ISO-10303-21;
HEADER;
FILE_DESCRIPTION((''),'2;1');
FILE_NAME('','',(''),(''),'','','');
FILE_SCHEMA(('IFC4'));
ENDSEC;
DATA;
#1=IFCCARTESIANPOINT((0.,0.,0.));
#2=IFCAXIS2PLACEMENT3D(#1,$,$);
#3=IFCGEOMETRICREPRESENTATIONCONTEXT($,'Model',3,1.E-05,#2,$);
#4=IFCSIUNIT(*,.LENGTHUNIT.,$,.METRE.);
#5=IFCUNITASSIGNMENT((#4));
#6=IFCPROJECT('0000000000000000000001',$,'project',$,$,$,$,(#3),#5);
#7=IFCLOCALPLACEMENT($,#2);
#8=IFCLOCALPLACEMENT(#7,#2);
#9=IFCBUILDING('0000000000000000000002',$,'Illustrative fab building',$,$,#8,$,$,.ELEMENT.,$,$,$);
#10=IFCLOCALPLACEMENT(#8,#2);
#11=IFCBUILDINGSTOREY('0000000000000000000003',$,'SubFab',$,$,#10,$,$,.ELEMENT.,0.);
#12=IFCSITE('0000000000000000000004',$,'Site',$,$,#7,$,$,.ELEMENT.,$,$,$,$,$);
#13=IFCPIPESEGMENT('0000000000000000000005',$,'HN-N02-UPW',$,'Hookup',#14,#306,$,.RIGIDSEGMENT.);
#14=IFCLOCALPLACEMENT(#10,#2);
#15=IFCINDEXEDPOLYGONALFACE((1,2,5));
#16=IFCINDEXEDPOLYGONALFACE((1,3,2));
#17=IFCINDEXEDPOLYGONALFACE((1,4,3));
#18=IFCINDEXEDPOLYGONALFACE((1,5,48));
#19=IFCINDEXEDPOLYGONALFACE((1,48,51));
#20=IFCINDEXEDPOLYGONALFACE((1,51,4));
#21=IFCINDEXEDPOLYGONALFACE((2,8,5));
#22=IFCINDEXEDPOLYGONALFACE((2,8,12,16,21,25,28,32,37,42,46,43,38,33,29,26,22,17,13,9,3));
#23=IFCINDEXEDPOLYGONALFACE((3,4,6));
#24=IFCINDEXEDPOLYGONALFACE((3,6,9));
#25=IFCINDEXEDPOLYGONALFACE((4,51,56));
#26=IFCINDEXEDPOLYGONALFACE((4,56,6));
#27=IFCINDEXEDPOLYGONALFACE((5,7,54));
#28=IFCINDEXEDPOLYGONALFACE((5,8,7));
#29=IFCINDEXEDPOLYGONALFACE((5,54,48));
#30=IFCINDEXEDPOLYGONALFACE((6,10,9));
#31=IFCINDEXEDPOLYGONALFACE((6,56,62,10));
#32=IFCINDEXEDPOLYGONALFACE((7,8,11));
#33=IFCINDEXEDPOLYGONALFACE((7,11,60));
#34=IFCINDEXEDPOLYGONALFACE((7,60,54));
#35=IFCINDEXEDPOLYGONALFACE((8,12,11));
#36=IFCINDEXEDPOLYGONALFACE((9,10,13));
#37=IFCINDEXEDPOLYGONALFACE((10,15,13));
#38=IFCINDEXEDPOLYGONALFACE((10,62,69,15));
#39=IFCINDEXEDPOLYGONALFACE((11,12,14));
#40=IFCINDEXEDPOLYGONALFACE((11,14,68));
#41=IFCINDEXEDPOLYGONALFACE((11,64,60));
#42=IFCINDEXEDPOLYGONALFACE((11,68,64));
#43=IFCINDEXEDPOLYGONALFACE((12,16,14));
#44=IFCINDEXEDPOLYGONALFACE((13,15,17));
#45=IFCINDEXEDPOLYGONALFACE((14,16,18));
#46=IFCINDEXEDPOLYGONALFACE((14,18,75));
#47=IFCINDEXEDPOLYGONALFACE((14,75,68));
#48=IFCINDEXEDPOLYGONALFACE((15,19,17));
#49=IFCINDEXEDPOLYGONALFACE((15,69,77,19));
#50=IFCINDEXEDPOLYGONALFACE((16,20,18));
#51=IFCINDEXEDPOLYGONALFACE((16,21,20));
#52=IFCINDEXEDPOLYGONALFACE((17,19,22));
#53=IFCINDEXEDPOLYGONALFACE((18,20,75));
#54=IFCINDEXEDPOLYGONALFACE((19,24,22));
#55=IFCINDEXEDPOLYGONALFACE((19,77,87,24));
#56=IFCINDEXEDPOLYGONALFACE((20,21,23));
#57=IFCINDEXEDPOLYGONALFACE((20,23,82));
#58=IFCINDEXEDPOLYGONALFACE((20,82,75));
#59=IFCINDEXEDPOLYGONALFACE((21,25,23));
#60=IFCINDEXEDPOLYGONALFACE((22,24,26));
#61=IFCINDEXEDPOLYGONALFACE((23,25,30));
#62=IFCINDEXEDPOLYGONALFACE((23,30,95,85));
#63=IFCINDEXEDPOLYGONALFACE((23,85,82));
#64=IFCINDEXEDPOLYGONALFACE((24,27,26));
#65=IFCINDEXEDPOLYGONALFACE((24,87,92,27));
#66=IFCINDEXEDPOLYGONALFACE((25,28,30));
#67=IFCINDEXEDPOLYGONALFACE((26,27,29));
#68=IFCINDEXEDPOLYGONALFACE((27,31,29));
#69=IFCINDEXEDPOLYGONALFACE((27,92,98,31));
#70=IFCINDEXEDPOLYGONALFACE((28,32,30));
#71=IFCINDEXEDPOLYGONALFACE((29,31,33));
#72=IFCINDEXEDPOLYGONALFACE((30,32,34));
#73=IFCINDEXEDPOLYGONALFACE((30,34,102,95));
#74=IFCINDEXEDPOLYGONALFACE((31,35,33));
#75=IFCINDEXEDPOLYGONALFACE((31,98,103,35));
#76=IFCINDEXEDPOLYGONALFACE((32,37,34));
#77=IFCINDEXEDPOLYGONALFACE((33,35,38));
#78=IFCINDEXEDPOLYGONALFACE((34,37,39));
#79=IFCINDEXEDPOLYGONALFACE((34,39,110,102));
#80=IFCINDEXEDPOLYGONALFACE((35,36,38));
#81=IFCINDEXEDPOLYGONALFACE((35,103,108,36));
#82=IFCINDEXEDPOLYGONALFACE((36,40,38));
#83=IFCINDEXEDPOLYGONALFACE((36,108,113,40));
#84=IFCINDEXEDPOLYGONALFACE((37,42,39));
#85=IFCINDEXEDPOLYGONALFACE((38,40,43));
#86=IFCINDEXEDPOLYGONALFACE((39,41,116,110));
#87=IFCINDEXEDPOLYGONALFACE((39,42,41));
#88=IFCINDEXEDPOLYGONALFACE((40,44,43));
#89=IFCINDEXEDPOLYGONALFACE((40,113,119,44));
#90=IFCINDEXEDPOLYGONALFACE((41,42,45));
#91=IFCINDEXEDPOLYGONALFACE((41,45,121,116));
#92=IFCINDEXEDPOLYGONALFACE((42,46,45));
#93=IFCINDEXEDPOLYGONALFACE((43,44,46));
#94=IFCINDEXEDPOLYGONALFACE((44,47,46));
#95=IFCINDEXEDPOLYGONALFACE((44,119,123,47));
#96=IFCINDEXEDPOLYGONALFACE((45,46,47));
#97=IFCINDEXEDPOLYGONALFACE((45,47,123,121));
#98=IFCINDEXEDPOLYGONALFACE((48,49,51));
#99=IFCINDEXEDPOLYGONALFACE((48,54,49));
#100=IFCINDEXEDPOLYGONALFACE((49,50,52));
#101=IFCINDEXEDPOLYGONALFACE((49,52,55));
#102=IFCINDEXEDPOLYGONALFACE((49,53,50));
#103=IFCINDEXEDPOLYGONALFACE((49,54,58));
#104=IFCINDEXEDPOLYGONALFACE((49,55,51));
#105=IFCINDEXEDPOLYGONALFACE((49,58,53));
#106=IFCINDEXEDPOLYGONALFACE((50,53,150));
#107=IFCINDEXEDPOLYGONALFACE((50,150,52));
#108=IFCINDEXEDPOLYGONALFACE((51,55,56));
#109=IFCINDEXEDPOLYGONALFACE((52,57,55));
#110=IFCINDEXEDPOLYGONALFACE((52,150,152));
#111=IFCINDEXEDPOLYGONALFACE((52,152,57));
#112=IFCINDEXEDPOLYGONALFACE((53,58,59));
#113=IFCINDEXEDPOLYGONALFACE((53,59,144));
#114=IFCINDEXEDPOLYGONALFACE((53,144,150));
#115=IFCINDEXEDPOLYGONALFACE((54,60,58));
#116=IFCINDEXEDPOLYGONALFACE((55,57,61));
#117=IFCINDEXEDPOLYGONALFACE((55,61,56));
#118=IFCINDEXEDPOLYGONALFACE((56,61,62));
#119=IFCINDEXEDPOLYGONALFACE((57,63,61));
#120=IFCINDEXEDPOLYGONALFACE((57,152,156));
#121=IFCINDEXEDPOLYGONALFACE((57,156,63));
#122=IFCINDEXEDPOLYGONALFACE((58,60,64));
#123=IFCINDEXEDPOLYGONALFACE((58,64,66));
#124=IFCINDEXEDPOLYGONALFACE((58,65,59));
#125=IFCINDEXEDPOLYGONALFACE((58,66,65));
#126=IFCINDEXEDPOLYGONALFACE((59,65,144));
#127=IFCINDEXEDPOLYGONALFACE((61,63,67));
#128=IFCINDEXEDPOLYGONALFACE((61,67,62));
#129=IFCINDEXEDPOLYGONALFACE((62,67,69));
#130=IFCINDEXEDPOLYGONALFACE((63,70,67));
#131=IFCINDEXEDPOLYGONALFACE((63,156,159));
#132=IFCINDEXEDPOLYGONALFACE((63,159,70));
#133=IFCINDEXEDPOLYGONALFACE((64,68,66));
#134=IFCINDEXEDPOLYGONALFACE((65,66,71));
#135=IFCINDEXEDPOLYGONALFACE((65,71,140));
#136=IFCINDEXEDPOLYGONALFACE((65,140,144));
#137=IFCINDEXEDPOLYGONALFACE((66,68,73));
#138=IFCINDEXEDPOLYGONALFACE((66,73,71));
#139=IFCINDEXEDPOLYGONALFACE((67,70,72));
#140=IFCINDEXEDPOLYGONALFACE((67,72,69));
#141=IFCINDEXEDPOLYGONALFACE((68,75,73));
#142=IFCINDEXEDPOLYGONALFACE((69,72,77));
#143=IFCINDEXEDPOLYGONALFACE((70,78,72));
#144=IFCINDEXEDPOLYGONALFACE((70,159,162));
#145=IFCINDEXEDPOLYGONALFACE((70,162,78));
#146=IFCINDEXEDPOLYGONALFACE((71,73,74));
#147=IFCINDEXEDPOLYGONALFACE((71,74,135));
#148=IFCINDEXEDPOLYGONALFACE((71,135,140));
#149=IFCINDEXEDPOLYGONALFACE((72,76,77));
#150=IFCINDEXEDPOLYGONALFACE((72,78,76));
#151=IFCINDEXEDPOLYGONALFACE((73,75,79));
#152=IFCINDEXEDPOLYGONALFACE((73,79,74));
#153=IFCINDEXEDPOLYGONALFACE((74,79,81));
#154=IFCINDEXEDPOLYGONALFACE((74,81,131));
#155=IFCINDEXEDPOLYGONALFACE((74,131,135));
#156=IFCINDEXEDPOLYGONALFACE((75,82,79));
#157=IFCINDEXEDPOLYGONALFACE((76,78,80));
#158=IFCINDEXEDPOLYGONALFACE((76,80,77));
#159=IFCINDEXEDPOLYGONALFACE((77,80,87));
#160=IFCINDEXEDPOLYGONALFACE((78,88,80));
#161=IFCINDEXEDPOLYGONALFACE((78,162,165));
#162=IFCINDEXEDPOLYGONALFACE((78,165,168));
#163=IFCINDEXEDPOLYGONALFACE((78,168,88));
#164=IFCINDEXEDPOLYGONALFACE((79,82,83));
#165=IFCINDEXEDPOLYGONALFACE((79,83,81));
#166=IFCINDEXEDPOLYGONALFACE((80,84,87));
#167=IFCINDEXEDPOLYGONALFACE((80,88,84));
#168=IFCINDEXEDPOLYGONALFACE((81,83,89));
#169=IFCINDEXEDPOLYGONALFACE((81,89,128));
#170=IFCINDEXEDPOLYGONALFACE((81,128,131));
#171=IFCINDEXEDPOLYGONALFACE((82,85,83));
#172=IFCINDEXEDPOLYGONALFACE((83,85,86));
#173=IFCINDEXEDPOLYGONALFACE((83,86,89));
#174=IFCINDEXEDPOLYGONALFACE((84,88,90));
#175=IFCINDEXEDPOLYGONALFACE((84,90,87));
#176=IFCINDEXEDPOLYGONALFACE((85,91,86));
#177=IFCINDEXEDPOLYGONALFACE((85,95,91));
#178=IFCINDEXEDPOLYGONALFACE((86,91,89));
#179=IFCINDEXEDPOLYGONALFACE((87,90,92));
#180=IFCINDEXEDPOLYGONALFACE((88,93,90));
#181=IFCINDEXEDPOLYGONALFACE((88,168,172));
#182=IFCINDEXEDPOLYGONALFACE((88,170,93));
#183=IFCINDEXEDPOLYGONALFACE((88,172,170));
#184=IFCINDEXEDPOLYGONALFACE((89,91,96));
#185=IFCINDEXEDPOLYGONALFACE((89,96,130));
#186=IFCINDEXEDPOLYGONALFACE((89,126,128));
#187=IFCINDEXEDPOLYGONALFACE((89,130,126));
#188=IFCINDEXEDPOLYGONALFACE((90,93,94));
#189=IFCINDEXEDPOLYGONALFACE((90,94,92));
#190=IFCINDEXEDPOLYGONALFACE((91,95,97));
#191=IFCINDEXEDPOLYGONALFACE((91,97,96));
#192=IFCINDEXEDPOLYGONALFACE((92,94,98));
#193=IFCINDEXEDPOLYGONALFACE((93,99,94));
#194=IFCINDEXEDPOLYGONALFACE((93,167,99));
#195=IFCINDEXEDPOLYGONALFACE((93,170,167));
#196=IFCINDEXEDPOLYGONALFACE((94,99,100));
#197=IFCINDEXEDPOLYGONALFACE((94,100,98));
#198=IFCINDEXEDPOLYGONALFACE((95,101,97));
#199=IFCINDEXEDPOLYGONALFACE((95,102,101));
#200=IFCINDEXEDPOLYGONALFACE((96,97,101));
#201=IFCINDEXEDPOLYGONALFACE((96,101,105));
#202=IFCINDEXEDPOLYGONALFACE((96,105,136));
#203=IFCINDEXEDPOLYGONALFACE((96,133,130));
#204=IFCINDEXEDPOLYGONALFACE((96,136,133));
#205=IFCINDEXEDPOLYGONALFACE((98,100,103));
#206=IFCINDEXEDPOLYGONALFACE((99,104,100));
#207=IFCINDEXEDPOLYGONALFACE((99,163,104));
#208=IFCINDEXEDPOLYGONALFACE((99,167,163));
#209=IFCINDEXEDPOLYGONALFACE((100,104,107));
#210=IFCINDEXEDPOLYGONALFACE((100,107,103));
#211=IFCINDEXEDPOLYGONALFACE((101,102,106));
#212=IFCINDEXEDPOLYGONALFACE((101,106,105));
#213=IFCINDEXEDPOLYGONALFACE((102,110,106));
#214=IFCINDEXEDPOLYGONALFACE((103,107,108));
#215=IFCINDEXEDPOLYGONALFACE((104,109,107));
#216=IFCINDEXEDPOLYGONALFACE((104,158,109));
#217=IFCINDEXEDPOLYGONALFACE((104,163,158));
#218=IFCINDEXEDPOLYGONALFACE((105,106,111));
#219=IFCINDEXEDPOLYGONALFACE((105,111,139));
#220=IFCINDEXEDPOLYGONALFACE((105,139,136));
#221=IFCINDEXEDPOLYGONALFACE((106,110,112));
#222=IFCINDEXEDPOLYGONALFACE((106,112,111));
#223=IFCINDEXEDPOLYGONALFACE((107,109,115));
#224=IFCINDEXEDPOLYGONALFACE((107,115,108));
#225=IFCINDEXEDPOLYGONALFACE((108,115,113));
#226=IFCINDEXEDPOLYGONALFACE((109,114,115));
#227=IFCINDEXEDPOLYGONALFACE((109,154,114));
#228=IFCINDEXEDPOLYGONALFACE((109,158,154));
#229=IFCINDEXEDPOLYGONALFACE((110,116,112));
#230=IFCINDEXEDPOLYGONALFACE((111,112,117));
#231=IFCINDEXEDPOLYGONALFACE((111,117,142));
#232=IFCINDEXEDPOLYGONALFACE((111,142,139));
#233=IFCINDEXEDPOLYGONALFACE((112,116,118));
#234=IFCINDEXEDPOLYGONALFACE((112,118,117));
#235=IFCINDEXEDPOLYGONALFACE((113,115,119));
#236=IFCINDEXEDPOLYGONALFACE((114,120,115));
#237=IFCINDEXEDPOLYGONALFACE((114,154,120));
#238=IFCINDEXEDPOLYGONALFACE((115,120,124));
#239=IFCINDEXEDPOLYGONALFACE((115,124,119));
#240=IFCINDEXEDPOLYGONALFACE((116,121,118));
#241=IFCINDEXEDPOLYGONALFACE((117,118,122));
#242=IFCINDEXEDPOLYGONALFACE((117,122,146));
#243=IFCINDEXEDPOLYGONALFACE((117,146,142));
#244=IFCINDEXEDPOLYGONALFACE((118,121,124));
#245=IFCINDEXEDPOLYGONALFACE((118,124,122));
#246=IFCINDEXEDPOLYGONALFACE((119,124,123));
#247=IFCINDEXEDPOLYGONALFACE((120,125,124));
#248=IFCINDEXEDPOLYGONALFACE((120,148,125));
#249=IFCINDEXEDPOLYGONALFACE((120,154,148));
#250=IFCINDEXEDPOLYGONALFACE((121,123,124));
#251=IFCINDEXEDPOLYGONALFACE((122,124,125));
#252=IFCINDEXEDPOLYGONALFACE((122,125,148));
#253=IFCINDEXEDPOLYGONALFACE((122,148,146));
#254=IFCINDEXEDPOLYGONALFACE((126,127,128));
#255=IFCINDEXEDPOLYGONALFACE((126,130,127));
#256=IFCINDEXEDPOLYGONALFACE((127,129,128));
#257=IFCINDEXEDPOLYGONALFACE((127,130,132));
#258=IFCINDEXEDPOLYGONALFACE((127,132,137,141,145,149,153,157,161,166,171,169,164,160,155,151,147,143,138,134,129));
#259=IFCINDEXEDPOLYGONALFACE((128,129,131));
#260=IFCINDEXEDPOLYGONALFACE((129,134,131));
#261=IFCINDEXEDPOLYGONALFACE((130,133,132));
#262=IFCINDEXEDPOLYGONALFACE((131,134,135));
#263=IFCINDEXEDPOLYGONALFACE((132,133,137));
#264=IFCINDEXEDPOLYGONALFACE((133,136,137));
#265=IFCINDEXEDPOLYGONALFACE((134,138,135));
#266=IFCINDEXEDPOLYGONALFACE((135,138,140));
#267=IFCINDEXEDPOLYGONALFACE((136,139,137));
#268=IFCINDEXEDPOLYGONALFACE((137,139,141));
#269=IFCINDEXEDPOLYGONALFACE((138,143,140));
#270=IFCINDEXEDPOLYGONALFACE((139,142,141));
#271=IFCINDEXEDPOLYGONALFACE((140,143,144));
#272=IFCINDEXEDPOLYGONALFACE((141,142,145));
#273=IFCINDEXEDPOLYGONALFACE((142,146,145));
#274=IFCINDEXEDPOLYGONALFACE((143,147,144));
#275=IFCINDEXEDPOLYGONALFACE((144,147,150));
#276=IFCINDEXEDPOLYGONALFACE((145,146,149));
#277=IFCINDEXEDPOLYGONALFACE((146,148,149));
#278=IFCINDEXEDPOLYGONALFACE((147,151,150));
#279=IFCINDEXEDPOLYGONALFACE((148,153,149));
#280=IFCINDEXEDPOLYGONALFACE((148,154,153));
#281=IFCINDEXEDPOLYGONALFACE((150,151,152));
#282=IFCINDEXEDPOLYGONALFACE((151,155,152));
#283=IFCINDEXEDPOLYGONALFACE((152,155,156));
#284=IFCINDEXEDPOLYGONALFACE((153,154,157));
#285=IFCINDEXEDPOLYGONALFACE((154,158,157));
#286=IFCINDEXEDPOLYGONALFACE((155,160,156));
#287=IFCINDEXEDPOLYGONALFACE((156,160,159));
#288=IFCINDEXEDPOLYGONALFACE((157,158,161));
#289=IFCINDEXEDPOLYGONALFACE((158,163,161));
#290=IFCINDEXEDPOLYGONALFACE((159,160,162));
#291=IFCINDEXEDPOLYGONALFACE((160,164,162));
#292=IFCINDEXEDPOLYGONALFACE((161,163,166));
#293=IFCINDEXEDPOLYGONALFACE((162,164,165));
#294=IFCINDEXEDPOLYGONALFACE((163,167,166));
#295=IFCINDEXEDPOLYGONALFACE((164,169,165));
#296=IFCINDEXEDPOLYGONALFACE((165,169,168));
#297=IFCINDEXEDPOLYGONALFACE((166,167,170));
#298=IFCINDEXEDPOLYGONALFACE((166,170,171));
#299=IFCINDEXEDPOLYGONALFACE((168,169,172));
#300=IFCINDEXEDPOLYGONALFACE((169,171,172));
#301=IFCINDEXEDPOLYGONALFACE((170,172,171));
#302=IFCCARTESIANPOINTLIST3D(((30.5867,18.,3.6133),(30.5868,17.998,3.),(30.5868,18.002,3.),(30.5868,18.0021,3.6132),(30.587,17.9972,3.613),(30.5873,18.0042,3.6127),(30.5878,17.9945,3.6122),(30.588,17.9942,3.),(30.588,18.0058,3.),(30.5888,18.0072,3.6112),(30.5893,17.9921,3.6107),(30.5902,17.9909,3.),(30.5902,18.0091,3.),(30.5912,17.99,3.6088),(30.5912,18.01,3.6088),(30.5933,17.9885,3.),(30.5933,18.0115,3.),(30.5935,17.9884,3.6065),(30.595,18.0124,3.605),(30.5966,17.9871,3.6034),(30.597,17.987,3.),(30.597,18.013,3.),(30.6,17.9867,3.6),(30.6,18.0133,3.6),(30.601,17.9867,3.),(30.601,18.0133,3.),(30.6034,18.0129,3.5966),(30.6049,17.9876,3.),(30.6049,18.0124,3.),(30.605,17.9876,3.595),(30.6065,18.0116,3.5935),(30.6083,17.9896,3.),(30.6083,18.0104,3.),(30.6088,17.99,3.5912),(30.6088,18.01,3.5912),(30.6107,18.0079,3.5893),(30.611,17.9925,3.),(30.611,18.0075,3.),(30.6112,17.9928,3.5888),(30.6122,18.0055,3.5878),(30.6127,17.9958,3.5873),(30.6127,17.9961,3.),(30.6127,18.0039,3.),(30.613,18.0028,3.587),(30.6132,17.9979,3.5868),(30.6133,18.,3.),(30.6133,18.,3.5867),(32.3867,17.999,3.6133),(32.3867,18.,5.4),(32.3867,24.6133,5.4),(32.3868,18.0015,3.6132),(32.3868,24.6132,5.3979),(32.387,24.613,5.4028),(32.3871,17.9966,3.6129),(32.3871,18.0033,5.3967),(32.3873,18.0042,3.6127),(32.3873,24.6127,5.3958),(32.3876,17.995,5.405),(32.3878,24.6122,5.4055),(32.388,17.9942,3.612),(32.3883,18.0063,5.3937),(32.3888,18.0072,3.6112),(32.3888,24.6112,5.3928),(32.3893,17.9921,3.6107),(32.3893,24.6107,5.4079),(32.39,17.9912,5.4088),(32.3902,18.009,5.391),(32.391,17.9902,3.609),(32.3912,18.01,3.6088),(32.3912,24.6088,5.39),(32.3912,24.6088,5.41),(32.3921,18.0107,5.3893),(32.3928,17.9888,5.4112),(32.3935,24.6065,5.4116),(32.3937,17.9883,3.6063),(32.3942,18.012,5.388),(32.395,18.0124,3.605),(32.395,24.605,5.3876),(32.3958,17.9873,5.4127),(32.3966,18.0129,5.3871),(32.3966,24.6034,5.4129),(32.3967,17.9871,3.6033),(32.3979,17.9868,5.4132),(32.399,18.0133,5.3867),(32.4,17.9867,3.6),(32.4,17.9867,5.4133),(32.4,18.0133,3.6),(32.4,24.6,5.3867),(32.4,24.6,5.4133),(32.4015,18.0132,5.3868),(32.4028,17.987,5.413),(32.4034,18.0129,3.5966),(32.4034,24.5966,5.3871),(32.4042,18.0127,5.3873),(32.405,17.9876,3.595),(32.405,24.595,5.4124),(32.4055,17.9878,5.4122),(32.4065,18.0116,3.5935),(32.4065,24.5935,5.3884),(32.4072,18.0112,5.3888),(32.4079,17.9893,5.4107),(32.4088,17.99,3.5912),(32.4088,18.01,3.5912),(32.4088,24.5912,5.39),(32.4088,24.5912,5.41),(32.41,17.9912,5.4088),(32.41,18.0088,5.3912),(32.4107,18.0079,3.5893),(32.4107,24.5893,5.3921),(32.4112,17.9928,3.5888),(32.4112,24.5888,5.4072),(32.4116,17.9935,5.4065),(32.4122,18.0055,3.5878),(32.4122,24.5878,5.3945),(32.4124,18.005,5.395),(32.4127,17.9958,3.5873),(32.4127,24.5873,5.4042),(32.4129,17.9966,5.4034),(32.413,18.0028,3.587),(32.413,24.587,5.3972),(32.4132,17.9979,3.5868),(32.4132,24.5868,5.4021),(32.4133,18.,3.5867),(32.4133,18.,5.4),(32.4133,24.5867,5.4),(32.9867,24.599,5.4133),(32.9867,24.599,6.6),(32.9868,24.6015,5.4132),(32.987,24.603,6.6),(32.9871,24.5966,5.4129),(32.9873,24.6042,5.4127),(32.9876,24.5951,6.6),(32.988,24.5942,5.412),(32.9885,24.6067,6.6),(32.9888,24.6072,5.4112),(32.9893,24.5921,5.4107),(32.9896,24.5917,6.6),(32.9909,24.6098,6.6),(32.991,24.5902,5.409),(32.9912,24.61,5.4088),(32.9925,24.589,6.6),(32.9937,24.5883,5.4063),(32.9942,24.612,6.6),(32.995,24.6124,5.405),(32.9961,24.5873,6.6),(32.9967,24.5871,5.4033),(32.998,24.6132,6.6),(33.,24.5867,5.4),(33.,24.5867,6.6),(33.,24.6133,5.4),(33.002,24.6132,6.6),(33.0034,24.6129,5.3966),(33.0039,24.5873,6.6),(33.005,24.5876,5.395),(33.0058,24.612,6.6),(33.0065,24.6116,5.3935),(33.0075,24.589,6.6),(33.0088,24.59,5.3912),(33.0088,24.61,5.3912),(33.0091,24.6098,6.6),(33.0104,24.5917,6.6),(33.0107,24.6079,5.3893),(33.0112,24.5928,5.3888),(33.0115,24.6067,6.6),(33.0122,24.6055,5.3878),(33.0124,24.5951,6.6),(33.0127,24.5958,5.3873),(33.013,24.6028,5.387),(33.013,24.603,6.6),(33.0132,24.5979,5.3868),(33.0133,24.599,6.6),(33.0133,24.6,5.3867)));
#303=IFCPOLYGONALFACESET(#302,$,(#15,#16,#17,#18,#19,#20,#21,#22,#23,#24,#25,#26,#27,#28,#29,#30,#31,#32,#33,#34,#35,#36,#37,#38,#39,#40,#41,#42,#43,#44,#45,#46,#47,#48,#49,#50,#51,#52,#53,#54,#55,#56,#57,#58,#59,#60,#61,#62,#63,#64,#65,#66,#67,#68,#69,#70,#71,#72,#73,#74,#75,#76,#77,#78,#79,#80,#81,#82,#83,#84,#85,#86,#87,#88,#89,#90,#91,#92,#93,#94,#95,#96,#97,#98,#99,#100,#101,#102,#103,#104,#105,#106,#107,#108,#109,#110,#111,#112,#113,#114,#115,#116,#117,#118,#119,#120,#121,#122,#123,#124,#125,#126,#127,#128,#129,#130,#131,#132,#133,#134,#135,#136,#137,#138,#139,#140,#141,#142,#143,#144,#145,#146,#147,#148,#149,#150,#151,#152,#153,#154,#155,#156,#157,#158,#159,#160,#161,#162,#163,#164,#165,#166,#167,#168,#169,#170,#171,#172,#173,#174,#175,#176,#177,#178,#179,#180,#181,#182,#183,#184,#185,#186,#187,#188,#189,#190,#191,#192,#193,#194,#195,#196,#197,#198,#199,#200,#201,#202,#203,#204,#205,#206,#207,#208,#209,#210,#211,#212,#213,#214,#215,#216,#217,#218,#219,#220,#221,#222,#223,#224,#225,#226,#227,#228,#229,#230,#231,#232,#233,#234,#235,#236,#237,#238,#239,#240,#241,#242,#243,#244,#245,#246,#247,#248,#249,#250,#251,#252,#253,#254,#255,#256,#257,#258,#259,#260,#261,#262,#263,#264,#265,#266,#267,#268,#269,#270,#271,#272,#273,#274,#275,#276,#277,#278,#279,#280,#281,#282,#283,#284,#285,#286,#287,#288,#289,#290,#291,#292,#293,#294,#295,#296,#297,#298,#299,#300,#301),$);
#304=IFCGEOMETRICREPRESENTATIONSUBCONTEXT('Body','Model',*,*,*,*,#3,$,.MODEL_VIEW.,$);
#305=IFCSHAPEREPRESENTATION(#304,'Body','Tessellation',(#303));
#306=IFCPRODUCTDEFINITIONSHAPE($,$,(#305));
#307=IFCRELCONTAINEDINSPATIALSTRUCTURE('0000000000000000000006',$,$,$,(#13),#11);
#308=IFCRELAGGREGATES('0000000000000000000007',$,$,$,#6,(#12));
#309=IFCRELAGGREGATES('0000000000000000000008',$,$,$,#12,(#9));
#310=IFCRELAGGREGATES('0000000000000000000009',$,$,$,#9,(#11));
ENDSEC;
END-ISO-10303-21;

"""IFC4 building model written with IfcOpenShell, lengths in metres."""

from ifc_helpers import new_model, entity, si_unit, origin, place, context, subcontext, project, spatial, element, save


model = new_model("IFC4")

# Units and contexts
model_context = context("Model", 3, precision=1e-05, world=origin())
body_context = subcontext(model_context, "Body", "Model", "MODEL_VIEW")
ifc_project = project(units=[si_unit("LENGTHUNIT", "METRE")], contexts=[model_context])

# Site, building, storey
site_placement = place(None, origin())
site = spatial("IfcSite", under=ifc_project, at=site_placement, Name="Site", CompositionType="ELEMENT")
building_placement = place(site_placement, origin())
building = spatial("IfcBuilding", under=site, at=building_placement, Name="Illustrative fab building", CompositionType="ELEMENT")
storey_placement = place(building_placement, origin())
storey = spatial("IfcBuildingStorey", under=building, at=storey_placement, Name="SubFab", CompositionType="ELEMENT", Elevation=0.0)

# Pipe segment
pipe_segment_1_placement = place(storey_placement, origin())
element("IfcPipeSegment", 1, at=pipe_segment_1_placement, inside=storey, Name="HN-N02-UPW", ObjectType="Hookup", PredefinedType="RIGIDSEGMENT", context=body_context, shape_type="AdvancedSweptSolid", body=[
    entity("IfcSweptDiskSolid", entity("IfcPolyline", [entity("IfcCartesianPoint", [30.6, 18.0, 3.0]), entity("IfcCartesianPoint", [30.6, 18.0, 3.6]), entity("IfcCartesianPoint", [32.4, 18.0, 3.6]), entity("IfcCartesianPoint", [32.4, 18.0, 5.4]), entity("IfcCartesianPoint", [32.4, 24.6, 5.4]), entity("IfcCartesianPoint", [33.0, 24.6, 5.4]), entity("IfcCartesianPoint", [33.0, 24.6, 6.6])]), 0.0133),
])

save(model, "model.ifc")
